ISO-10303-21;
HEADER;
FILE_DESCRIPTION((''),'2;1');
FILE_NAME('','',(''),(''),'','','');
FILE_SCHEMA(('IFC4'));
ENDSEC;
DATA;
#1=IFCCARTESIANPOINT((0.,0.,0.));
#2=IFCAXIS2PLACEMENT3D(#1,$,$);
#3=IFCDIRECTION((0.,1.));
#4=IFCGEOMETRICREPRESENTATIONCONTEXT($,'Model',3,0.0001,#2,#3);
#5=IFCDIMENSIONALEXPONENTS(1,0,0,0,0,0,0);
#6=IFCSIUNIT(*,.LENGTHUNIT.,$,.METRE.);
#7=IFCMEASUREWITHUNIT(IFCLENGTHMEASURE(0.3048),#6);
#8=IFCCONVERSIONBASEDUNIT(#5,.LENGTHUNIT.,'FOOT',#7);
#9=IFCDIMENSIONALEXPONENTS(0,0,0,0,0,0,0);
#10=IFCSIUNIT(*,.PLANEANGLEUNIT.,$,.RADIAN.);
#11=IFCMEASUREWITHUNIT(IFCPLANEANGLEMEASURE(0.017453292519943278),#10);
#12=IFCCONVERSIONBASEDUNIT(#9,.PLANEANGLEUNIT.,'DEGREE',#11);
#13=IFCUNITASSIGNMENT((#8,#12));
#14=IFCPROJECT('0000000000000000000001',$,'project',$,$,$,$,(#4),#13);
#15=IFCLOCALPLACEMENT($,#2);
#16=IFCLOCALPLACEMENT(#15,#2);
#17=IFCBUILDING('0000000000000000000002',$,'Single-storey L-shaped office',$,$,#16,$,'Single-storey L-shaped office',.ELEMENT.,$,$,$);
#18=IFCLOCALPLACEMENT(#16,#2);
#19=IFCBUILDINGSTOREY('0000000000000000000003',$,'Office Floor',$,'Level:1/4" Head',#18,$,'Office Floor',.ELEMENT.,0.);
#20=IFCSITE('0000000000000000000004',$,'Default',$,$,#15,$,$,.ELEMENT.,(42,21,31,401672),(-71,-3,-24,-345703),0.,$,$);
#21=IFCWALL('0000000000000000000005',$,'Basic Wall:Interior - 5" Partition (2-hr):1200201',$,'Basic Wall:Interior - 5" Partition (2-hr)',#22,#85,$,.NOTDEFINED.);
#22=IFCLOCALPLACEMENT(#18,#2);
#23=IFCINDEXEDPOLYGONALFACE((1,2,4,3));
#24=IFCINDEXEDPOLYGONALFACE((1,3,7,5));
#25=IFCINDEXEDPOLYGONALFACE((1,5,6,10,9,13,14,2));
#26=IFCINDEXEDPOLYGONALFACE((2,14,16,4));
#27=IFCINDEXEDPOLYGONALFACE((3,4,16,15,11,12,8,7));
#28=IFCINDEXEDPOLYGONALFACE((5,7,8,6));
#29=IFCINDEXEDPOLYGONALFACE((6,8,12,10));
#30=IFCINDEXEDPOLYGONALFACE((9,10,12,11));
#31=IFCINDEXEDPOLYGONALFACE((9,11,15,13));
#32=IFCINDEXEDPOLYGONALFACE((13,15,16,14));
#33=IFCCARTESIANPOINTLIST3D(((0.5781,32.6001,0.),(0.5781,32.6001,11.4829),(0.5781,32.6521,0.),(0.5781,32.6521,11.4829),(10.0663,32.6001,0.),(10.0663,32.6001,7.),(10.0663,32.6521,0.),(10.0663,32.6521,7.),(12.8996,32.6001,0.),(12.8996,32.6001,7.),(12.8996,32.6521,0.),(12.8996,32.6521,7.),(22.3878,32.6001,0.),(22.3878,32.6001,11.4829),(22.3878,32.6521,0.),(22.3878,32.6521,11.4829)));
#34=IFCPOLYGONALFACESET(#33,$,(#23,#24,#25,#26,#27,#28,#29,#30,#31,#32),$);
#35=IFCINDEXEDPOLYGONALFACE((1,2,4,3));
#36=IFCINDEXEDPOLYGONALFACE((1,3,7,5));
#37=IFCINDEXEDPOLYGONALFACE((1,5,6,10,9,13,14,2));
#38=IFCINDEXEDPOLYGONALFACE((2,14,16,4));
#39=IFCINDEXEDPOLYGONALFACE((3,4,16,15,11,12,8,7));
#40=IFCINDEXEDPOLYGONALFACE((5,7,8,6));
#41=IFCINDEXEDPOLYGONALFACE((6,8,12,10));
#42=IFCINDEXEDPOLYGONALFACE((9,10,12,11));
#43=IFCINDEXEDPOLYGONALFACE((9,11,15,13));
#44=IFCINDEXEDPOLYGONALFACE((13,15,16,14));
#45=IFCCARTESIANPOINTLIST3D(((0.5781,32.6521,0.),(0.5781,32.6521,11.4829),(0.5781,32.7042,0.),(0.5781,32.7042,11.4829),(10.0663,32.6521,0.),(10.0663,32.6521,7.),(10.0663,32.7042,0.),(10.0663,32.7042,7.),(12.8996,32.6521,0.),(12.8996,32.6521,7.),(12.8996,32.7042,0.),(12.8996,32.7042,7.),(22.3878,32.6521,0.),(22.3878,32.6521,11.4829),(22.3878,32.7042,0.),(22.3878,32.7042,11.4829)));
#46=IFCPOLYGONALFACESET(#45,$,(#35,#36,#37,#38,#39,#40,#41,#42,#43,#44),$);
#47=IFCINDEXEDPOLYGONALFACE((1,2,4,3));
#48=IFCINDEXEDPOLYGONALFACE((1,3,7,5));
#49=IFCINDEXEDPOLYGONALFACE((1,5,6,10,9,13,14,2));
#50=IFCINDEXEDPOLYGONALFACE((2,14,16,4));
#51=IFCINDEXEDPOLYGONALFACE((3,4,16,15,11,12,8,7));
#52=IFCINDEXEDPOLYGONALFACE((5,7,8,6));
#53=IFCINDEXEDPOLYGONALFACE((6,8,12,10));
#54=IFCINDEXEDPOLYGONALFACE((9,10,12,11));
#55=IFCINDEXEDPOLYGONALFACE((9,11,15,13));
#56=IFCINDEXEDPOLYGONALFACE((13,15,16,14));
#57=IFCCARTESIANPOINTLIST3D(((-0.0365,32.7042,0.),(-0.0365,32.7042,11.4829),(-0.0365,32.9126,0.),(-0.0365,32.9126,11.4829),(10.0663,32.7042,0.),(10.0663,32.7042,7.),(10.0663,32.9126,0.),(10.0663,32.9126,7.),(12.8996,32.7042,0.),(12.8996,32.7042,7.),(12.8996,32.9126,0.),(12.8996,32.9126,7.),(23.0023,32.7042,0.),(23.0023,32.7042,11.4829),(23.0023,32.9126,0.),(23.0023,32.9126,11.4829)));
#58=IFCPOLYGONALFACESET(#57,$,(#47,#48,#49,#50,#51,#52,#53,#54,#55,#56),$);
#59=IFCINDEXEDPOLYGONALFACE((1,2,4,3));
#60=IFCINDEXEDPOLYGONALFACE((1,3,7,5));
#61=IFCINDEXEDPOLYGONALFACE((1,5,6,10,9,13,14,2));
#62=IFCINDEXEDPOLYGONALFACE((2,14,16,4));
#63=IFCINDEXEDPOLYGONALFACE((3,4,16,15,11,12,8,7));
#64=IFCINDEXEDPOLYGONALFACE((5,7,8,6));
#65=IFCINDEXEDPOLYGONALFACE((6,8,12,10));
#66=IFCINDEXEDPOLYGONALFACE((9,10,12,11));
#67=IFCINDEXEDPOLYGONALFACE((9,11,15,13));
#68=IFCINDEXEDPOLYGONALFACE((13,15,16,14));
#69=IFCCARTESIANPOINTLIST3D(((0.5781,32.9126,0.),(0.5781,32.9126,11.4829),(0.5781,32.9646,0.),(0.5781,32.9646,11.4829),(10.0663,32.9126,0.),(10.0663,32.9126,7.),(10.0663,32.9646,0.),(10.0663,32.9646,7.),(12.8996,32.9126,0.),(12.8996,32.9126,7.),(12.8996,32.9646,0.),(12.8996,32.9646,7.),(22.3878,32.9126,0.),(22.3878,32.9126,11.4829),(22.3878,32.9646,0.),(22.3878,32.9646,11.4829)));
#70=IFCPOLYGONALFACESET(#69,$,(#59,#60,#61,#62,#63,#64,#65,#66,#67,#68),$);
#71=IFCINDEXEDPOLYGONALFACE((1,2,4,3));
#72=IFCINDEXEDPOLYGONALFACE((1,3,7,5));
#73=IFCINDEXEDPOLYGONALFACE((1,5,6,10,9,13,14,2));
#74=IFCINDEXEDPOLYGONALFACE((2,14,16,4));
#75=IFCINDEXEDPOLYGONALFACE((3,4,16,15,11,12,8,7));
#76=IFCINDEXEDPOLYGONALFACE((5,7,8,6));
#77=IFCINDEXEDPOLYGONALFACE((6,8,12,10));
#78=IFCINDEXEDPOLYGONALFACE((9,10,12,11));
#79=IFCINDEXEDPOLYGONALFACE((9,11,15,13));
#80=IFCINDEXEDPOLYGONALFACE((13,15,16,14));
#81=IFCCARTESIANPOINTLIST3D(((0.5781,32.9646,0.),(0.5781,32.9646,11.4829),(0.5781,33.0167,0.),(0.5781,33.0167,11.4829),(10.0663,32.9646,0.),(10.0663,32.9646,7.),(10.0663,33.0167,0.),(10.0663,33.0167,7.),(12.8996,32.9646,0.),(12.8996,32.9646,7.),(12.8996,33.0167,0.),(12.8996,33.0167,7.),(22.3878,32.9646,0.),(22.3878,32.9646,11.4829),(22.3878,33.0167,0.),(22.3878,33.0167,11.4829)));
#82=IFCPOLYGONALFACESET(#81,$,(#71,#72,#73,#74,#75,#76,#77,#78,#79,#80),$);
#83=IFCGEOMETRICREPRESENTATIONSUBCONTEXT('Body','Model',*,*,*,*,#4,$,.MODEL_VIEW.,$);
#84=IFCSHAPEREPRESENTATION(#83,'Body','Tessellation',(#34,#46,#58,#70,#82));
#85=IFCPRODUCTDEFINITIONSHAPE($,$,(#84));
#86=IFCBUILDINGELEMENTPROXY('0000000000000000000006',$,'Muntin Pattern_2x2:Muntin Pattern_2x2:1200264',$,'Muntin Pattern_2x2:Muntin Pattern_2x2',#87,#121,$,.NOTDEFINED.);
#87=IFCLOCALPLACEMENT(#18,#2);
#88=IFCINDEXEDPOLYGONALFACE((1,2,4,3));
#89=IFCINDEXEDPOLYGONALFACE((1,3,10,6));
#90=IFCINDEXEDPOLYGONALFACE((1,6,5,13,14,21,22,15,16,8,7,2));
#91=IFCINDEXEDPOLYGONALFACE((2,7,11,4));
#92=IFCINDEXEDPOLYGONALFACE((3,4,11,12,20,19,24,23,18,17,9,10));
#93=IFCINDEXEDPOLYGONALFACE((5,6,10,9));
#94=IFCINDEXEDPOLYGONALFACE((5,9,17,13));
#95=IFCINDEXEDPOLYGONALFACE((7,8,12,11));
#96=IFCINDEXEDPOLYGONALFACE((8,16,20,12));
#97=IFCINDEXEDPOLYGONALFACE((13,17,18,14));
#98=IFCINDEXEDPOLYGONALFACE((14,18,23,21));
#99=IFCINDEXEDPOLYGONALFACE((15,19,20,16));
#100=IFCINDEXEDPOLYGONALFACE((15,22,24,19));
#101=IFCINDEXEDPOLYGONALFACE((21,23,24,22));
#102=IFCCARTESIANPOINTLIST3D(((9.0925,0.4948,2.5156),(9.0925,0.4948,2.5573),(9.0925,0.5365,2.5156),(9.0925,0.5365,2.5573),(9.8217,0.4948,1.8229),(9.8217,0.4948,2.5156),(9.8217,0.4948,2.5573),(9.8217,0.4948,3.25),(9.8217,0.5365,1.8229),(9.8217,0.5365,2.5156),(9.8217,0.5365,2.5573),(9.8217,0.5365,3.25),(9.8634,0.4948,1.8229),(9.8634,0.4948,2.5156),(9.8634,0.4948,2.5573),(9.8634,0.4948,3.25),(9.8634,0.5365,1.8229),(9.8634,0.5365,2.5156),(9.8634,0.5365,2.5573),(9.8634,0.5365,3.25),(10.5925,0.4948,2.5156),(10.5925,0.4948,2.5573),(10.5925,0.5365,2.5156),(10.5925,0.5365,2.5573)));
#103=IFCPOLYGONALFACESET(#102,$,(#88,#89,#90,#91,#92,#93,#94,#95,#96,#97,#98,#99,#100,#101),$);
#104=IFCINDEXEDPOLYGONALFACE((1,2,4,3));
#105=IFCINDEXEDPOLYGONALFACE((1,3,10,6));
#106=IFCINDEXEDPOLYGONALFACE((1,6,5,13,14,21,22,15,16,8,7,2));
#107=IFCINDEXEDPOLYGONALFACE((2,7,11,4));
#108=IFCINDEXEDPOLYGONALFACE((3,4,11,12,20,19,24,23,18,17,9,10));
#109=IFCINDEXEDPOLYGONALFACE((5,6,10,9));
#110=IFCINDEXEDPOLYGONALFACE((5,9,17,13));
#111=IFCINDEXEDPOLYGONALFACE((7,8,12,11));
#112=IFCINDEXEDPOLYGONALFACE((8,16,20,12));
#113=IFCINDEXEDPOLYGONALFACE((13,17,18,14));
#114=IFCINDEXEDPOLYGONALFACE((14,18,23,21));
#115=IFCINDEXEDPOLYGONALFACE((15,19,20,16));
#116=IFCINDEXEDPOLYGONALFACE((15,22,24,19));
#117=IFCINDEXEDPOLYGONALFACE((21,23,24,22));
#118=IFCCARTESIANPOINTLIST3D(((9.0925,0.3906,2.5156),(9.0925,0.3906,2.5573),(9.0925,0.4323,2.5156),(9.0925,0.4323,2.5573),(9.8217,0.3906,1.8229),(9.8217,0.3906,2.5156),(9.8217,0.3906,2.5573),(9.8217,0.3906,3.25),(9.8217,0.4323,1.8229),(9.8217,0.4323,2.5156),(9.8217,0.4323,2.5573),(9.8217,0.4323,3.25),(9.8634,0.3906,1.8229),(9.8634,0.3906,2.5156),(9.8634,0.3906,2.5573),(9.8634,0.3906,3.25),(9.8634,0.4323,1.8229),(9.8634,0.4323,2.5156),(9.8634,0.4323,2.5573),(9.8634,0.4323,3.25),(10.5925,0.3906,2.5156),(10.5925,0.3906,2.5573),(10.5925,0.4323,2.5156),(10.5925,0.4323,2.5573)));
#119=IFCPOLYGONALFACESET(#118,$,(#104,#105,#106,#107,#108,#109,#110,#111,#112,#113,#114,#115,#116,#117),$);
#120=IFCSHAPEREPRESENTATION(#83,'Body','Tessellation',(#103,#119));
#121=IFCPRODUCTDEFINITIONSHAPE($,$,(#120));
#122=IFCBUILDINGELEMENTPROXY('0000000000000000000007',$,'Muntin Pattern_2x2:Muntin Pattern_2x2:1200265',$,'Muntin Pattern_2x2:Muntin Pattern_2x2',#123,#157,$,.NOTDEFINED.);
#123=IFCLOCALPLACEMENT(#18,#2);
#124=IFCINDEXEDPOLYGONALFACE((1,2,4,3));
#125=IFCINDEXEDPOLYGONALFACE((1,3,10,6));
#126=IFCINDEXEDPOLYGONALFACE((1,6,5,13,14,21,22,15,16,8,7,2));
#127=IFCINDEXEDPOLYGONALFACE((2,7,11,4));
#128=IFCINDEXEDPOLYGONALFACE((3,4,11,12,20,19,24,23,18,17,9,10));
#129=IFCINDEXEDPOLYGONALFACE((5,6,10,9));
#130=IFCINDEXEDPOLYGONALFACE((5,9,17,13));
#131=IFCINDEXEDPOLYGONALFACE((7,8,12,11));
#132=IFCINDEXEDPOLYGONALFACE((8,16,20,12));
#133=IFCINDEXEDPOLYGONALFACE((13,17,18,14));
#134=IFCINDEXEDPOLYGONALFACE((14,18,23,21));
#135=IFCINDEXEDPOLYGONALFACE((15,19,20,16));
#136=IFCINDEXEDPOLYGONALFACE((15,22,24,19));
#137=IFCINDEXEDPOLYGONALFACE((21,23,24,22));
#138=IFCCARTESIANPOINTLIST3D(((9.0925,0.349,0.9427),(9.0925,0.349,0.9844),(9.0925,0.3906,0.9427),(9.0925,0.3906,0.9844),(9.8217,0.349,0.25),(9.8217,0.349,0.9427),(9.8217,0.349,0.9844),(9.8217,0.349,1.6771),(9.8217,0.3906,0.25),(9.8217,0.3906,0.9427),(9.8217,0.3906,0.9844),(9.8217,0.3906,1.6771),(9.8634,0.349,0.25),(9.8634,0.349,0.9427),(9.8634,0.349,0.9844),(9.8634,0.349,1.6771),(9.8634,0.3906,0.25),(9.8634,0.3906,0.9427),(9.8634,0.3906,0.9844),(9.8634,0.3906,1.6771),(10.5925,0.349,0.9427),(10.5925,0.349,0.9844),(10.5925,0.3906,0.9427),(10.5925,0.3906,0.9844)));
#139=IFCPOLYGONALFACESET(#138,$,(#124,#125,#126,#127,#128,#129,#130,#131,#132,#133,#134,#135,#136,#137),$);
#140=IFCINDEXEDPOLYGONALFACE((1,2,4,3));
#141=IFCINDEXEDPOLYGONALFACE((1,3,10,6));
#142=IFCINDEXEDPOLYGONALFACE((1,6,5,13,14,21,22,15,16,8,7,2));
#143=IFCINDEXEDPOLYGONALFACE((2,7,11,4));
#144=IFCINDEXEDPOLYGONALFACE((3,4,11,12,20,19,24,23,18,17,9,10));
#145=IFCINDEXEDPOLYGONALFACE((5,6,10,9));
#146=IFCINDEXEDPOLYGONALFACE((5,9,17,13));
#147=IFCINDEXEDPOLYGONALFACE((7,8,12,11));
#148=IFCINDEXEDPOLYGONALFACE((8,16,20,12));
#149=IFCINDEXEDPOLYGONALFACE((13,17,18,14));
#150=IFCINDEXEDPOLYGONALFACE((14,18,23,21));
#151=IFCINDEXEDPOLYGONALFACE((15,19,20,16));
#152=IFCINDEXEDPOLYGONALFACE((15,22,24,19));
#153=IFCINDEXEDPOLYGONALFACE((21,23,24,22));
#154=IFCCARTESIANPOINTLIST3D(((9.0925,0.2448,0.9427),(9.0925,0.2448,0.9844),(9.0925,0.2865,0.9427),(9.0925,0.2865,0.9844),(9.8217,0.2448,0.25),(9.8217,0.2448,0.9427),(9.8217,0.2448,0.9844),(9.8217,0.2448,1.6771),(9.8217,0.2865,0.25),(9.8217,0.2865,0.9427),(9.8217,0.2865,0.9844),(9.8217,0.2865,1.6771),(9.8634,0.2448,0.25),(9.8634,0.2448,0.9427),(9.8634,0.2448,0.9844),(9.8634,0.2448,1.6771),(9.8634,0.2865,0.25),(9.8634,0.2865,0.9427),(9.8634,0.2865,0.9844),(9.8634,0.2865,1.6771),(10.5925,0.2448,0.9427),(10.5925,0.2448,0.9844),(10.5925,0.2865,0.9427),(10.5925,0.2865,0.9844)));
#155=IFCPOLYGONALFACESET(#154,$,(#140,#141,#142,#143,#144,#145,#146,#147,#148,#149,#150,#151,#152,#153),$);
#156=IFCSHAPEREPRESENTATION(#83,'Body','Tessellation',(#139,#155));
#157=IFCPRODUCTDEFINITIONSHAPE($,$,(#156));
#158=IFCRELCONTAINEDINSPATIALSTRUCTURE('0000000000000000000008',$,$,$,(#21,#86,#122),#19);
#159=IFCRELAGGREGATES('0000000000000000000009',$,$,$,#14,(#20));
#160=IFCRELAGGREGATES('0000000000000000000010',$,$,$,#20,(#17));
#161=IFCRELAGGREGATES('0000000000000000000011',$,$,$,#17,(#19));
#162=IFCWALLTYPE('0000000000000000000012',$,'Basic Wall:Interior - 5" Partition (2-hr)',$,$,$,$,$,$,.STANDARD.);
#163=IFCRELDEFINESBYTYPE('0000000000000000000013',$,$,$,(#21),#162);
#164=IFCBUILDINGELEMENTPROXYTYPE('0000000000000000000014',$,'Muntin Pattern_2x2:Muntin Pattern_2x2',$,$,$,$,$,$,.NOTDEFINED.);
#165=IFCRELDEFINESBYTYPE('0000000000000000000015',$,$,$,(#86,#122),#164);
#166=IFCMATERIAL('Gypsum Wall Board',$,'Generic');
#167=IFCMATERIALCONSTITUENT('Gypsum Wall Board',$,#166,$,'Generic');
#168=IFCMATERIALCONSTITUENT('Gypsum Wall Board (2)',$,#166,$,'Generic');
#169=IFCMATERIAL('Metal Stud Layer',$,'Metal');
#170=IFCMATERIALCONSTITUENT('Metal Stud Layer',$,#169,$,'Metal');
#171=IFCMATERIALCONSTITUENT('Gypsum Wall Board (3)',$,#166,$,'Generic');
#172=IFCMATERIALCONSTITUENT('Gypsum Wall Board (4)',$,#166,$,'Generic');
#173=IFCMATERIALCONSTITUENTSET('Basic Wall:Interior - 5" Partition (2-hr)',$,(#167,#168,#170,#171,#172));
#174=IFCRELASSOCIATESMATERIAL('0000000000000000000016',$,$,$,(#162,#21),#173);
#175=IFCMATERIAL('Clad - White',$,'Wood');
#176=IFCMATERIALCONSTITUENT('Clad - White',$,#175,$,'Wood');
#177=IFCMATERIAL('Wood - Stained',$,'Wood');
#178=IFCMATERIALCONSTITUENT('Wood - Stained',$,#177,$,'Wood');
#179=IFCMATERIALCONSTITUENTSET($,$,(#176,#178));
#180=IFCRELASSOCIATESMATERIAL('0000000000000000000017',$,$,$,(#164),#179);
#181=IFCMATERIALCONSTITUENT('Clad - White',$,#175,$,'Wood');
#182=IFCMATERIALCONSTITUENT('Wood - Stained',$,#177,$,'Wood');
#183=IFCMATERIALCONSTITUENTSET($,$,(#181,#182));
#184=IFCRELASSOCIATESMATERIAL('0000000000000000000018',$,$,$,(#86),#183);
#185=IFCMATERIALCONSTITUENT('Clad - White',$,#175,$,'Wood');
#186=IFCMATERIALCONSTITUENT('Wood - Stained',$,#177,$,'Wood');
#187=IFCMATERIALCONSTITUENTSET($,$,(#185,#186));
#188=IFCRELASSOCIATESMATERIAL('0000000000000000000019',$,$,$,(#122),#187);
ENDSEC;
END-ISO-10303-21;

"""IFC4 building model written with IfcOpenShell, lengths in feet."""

from ifc_helpers import new_model, entity, si_unit, converted_unit, direction, frame, origin, place, context, subcontext, project, spatial, indexed_curve, outline, extrude, source, transform, mapped, material, constituent, constituent_set, type_object, type_shapes, element, save


model = new_model("IFC4")

# Units and contexts
model_context = context("Model", 3, precision=0.0001, world=origin(), true_north=direction((0.0, 1.0)))
body_context = subcontext(model_context, "Body", "Model", "MODEL_VIEW")
ifc_project = project(units=[converted_unit("LENGTHUNIT", "FOOT", entity("IfcLengthMeasure", 0.3048), si_unit("LENGTHUNIT", "METRE"), dimensions=[1, 0, 0, 0, 0, 0, 0]), converted_unit("PLANEANGLEUNIT", "DEGREE", entity("IfcPlaneAngleMeasure", 0.017453292519943278), si_unit("PLANEANGLEUNIT", "RADIAN"), dimensions=[0, 0, 0, 0, 0, 0, 0])], contexts=[model_context])

# Site, building, storey
site_placement = place(None, origin())
site = spatial("IfcSite", under=ifc_project, at=site_placement, Name="Default", CompositionType="ELEMENT", RefLatitude=(42, 21, 31, 401672), RefLongitude=(-71, -3, -24, -345703), RefElevation=0.0)
building_placement = place(site_placement, origin())
building = spatial("IfcBuilding", under=site, at=building_placement, Name="Single-storey L-shaped office", LongName="Single-storey L-shaped office", CompositionType="ELEMENT")
storey_placement = place(building_placement, origin())
storey = spatial("IfcBuildingStorey", under=building, at=storey_placement, Name="Office Floor", ObjectType="Level:1/4\" Head", LongName="Office Floor", CompositionType="ELEMENT", Elevation=0.0)

# Shared definitions
ifc_material_1 = material(Name="Metal Stud Layer", Category="Metal")
ifc_material_2 = material(Name="Gypsum Wall Board", Category="Generic")
ifc_material_3 = material(Name="Wood - Stained", Category="Wood")

# Wall, opening
ifc_constituent_1 = constituent(ifc_material_2, Name="Gypsum Wall Board", Category="Generic")
ifc_constituent_2 = constituent(ifc_material_2, Name="Gypsum Wall Board (2)", Category="Generic")
ifc_constituent_3 = constituent(ifc_material_1, Name="Metal Stud Layer", Category="Metal")
ifc_constituent_4 = constituent(ifc_material_2, Name="Gypsum Wall Board (3)", Category="Generic")
ifc_constituent_5 = constituent(ifc_material_2, Name="Gypsum Wall Board (4)", Category="Generic")
ifc_constituent_set_1 = constituent_set(constituents=[ifc_constituent_1, ifc_constituent_2, ifc_constituent_3, ifc_constituent_4, ifc_constituent_5], Name="Basic Wall:Interior - 5\" Partition (2-hr)")
wall_type_1 = type_object("IfcWallType", Name="Basic Wall:Interior - 5\" Partition (2-hr)", PredefinedType="STANDARD", material=ifc_constituent_set_1)
wall_1_placement = place(storey_placement, frame((0.5781, 32.8084, 0.0)))
wall_1 = element("IfcWall", 1, at=wall_1_placement, inside=storey, type_object=wall_type_1, material=ifc_constituent_set_1, Name="Basic Wall:Interior - 5\" Partition (2-hr):1200201", ObjectType="Basic Wall:Interior - 5\" Partition (2-hr)", PredefinedType="NOTDEFINED", context=body_context, shape_type="SweptSolid", body=[
    extrude(outline(indexed_curve([(-6.8622, -10.9048), (4.6207, -10.9048), (4.6207, -1.4167), (-2.3793, -1.4167), (-2.3793, 1.4167), (4.6207, 1.4167), (4.6207, 10.9048), (-6.8622, 10.9048), (-6.8622, -10.9048)], self_intersect=False)), frame((10.9048, -0.2083, 4.6207), z_axis=(0.0, 1.0, 0.0), x_axis=(0.0, 0.0, -1.0)), (0.0, 0.0, 1.0), 0.0521),
    extrude(outline(indexed_curve([(-4.6207, -10.9048), (6.8622, -10.9048), (6.8622, 10.9048), (-4.6207, 10.9048), (-4.6207, 1.4167), (2.3793, 1.4167), (2.3793, -1.4167), (-4.6207, -1.4167), (-4.6207, -10.9048)], self_intersect=False)), frame((10.9048, -0.1562, 4.6207), z_axis=(0.0, 1.0, 0.0), x_axis=(0.0, 0.0, 1.0)), (0.0, 0.0, 1.0), 0.0521),
    extrude(outline(indexed_curve([(-4.6207, -11.5194), (6.8622, -11.5194), (6.8622, 11.5194), (-4.6207, 11.5194), (-4.6207, 1.4167), (2.3793, 1.4167), (2.3793, -1.4167), (-4.6207, -1.4167), (-4.6207, -11.5194)], self_intersect=False)), frame((10.9048, -0.1042, 4.6207), z_axis=(0.0, 1.0, 0.0), x_axis=(0.0, 0.0, 1.0)), (0.0, 0.0, 1.0), 0.2083),
    extrude(outline(indexed_curve([(-4.6207, -10.9048), (6.8622, -10.9048), (6.8622, 10.9048), (-4.6207, 10.9048), (-4.6207, 1.4167), (2.3793, 1.4167), (2.3793, -1.4167), (-4.6207, -1.4167), (-4.6207, -10.9048)], self_intersect=False)), frame((10.9048, 0.1042, 4.6207), z_axis=(0.0, 1.0, 0.0), x_axis=(0.0, 0.0, 1.0)), (0.0, 0.0, 1.0), 0.0521),
    extrude(outline(indexed_curve([(-4.6207, -10.9048), (6.8622, -10.9048), (6.8622, 10.9048), (-4.6207, 10.9048), (-4.6207, 1.4167), (2.3793, 1.4167), (2.3793, -1.4167), (-4.6207, -1.4167), (-4.6207, -10.9048)], self_intersect=False)), frame((10.9048, 0.1562, 4.6207), z_axis=(0.0, 1.0, 0.0), x_axis=(0.0, 0.0, 1.0)), (0.0, 0.0, 1.0), 0.0521),
])
opening_1_placement = place(wall_1_placement, frame((9.4881, -0.2083, 0.0)))
element("IfcOpeningElement", 2, at=opening_1_placement, cuts=wall_1, PredefinedType="OPENING", context=body_context, shape_type="SweptSolid", body=[
    extrude(outline(indexed_curve([(0.0, 2.8333), (0.0, 0.0), (7.0, 0.0), (7.0, 2.8333), (0.0, 2.8333)], self_intersect=False)), frame((0.0, 0.0, 0.0), z_axis=(0.0, 1.0, 0.0), x_axis=(0.0, 0.0, 1.0)), (0.0, 0.0, 1.0), 0.4167),
])

# Building element proxies
ifc_material_4 = material(Name="Clad - White", Category="Wood")
ifc_constituent_6 = constituent(ifc_material_4, Name="Clad - White", Category="Wood")
ifc_constituent_7 = constituent(ifc_material_3, Name="Wood - Stained", Category="Wood")
ifc_constituent_set_2 = constituent_set(constituents=[ifc_constituent_6, ifc_constituent_7])
ifc_constituent_8 = constituent(ifc_material_4, Name="Clad - White", Category="Wood")
ifc_constituent_9 = constituent(ifc_material_3, Name="Wood - Stained", Category="Wood")
ifc_constituent_set_3 = constituent_set(constituents=[ifc_constituent_8, ifc_constituent_9])
building_element_proxy_type_1 = type_object("IfcBuildingElementProxyType", Name="Muntin Pattern_2x2:Muntin Pattern_2x2", PredefinedType="NOTDEFINED", material=ifc_constituent_set_3)
shared_shape_1 = source(origin(), body_context, "Body", "SweptSolid", [
    extrude(outline(indexed_curve([(0.0208, -0.0208), (0.7135, -0.0208), (0.7135, 0.0208), (0.0208, 0.0208), (0.0208, 0.75), (-0.0208, 0.75), (-0.0208, 0.0208), (-0.7135, 0.0208), (-0.7135, -0.0208), (-0.0208, -0.0208), (-0.0208, -0.75), (0.0208, -0.75), (0.0208, -0.0208)], self_intersect=False)), frame((0.0, 0.0312, 0.7135), z_axis=(0.0, 1.0, 0.0), x_axis=(0.0, 0.0, 1.0)), (0.0, 0.0, 1.0), 0.0417),
    extrude(outline(indexed_curve([(0.0208, -0.0208), (0.7135, -0.0208), (0.7135, 0.0208), (0.0208, 0.0208), (0.0208, 0.75), (-0.0208, 0.75), (-0.0208, 0.0208), (-0.7135, 0.0208), (-0.7135, -0.0208), (-0.0208, -0.0208), (-0.0208, -0.75), (0.0208, -0.75), (0.0208, -0.0208)], self_intersect=False)), frame((0.0, -0.0729, 0.7135), z_axis=(0.0, 1.0, 0.0), x_axis=(0.0, 0.0, 1.0)), (0.0, 0.0, 1.0), 0.0417),
])
type_shapes(building_element_proxy_type_1, [shared_shape_1])
proxy_1_placement = place(storey_placement, frame((9.8425, 0.4635, 1.8229)))
element("IfcBuildingElementProxy", 3, at=proxy_1_placement, inside=storey, type_object=building_element_proxy_type_1, material=ifc_constituent_set_2, Name="Muntin Pattern_2x2:Muntin Pattern_2x2:1200264", ObjectType="Muntin Pattern_2x2:Muntin Pattern_2x2", PredefinedType="NOTDEFINED", context=body_context, shape_type="MappedRepresentation", body=[
    mapped(shared_shape_1, transform((0.0, 0.0, 0.0), scale=1.0)),
])
ifc_constituent_10 = constituent(ifc_material_4, Name="Clad - White", Category="Wood")
ifc_constituent_11 = constituent(ifc_material_3, Name="Wood - Stained", Category="Wood")
ifc_constituent_set_4 = constituent_set(constituents=[ifc_constituent_10, ifc_constituent_11])
proxy_2_placement = place(storey_placement, frame((9.8425, 0.3177, 0.25)))
element("IfcBuildingElementProxy", 4, at=proxy_2_placement, inside=storey, type_object=building_element_proxy_type_1, material=ifc_constituent_set_4, Name="Muntin Pattern_2x2:Muntin Pattern_2x2:1200265", ObjectType="Muntin Pattern_2x2:Muntin Pattern_2x2", PredefinedType="NOTDEFINED", context=body_context, shape_type="MappedRepresentation", body=[
    mapped(shared_shape_1, transform((0.0, 0.0, 0.0), scale=1.0)),
])

save(model, "model.ifc")
